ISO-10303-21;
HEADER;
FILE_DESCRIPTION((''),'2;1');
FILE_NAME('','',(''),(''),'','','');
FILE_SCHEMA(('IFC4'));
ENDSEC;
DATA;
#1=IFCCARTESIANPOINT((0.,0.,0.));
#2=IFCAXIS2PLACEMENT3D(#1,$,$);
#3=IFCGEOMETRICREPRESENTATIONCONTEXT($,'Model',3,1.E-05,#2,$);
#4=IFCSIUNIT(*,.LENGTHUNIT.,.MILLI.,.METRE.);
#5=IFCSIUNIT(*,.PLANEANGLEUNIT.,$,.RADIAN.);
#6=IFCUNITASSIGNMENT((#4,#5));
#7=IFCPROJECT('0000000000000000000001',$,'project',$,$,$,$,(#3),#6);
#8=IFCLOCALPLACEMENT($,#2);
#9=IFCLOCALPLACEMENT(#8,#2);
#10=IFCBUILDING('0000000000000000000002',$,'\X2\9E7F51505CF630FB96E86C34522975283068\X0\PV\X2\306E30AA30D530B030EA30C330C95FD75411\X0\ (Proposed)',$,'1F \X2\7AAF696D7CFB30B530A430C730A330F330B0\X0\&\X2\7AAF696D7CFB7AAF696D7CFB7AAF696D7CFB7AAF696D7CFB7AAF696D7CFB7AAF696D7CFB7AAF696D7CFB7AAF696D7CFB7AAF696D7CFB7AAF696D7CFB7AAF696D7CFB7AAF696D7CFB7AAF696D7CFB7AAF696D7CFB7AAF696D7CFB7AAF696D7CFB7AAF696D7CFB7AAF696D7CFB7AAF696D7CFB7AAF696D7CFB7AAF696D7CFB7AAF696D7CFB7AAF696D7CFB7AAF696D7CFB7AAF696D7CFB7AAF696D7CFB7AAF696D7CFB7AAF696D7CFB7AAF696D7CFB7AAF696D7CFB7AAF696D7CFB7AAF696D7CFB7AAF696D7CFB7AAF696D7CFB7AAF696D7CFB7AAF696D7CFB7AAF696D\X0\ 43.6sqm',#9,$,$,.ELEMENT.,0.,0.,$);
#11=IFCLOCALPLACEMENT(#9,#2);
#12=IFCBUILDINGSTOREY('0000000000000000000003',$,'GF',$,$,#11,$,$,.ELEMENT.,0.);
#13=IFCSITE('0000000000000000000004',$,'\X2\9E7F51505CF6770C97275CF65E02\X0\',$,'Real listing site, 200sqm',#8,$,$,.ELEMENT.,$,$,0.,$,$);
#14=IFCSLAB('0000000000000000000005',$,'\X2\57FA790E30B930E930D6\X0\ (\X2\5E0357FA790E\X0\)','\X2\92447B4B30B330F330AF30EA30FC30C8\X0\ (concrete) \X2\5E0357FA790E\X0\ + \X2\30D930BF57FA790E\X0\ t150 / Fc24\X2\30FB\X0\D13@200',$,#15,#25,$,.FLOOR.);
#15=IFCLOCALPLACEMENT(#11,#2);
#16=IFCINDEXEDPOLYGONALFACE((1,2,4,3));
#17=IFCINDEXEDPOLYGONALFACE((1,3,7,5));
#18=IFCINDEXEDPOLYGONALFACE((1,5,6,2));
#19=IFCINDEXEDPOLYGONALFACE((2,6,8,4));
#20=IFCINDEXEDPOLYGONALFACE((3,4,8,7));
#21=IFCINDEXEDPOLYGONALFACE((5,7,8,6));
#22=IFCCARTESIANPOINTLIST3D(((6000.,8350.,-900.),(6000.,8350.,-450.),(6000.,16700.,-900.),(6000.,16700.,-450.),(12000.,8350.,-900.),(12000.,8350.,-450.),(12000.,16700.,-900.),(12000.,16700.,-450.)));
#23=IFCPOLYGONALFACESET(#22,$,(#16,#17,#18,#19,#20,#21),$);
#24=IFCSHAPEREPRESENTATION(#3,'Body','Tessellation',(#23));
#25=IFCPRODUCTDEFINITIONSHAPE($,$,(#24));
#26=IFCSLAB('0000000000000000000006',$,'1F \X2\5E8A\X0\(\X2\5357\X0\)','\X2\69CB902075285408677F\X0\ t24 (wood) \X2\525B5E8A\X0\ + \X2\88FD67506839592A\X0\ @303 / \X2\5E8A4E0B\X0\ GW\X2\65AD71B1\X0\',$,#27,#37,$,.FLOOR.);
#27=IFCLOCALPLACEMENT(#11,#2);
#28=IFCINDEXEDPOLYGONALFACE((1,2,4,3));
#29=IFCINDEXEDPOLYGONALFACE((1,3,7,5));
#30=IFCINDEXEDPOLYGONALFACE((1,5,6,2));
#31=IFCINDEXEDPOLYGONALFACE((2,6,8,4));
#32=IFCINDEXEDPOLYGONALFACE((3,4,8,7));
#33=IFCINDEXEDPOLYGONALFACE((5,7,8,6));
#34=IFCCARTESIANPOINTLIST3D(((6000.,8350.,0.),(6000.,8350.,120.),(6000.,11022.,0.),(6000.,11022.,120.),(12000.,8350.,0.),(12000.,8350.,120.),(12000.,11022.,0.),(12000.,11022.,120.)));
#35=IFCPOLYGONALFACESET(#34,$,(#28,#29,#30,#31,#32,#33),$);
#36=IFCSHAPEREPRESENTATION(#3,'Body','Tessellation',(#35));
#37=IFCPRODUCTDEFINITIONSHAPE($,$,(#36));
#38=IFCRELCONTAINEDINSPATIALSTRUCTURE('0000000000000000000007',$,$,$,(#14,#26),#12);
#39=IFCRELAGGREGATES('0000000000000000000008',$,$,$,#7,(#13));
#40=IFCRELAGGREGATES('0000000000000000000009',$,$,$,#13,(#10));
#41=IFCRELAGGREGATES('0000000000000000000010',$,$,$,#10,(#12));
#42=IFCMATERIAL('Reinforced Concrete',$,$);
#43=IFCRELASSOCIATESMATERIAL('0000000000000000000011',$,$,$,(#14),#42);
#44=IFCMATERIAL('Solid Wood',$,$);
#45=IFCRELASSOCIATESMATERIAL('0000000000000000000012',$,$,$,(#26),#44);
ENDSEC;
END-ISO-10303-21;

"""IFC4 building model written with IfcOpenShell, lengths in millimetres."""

from ifc_helpers import new_model, si_unit, frame, frame_2d, origin, place, context, project, spatial, rectangle, extrude, material, element, save


model = new_model("IFC4")

# Units and contexts
model_context = context("Model", 3, precision=1e-05, world=origin())
ifc_project = project(units=[si_unit("LENGTHUNIT", "METRE", prefix="MILLI"), si_unit("PLANEANGLEUNIT", "RADIAN")], contexts=[model_context])

# Site, building, storey
site_placement = place(None, origin())
site = spatial("IfcSite", under=ifc_project, at=site_placement, Name="鹿児島県霧島市", ObjectType="Real listing site, 200sqm", CompositionType="ELEMENT", RefElevation=0.0)
building_placement = place(site_placement, origin())
building = spatial("IfcBuilding", under=site, at=building_placement, Name="鹿児島・雨水利用とPVのオフグリッド志向 (Proposed)", ObjectType="1F 窯業系サイディング&窯業系窯業系窯業系窯業系窯業系窯業系窯業系窯業系窯業系窯業系窯業系窯業系窯業系窯業系窯業系窯業系窯業系窯業系窯業系窯業系窯業系窯業系窯業系窯業系窯業系窯業系窯業系窯業系窯業系窯業系窯業系窯業系窯業系窯業系窯業系窯業系窯業 43.6sqm", CompositionType="ELEMENT", ElevationOfRefHeight=0.0, ElevationOfTerrain=0.0)
storey_placement = place(building_placement, origin())
storey = spatial("IfcBuildingStorey", under=building, at=storey_placement, Name="GF", CompositionType="ELEMENT", Elevation=0.0)

# Shared definitions
ifc_material_1 = material(Name="Solid Wood")

# Slabs
ifc_material_2 = material(Name="Reinforced Concrete")
slab_1_placement = place(storey_placement, frame((3000.0, 4175.0, -450.0)))
element("IfcSlab", 1, at=slab_1_placement, inside=storey, material=ifc_material_2, Name="基礎スラブ (布基礎)", Description="鉄筋コンクリート (concrete) 布基礎 + ベタ基礎 t150 / Fc24・D13@200", PredefinedType="FLOOR", context=model_context, shape_type="SweptSolid", body=[
    extrude(rectangle(XDim=6000.0, YDim=8350.0, at=frame_2d((3000.0, 4175.0))), frame((3000.0, 4175.0, -450.0)), (0.0, 0.0, 1.0), 450.0),
])
slab_2_placement = place(storey_placement, frame((3000.0, 4175.0, 0.0)))
element("IfcSlab", 2, at=slab_2_placement, inside=storey, material=ifc_material_1, Name="1F 床(南)", Description="構造用合板 t24 (wood) 剛床 + 製材根太 @303 / 床下 GW断熱", PredefinedType="FLOOR", context=model_context, shape_type="SweptSolid", body=[
    extrude(rectangle(XDim=6000.0, YDim=2672.0, at=frame_2d((3000.0, 1336.0))), frame((3000.0, 4175.0, 0.0)), (0.0, 0.0, 1.0), 120.0),
])

save(model, "model.ifc")
